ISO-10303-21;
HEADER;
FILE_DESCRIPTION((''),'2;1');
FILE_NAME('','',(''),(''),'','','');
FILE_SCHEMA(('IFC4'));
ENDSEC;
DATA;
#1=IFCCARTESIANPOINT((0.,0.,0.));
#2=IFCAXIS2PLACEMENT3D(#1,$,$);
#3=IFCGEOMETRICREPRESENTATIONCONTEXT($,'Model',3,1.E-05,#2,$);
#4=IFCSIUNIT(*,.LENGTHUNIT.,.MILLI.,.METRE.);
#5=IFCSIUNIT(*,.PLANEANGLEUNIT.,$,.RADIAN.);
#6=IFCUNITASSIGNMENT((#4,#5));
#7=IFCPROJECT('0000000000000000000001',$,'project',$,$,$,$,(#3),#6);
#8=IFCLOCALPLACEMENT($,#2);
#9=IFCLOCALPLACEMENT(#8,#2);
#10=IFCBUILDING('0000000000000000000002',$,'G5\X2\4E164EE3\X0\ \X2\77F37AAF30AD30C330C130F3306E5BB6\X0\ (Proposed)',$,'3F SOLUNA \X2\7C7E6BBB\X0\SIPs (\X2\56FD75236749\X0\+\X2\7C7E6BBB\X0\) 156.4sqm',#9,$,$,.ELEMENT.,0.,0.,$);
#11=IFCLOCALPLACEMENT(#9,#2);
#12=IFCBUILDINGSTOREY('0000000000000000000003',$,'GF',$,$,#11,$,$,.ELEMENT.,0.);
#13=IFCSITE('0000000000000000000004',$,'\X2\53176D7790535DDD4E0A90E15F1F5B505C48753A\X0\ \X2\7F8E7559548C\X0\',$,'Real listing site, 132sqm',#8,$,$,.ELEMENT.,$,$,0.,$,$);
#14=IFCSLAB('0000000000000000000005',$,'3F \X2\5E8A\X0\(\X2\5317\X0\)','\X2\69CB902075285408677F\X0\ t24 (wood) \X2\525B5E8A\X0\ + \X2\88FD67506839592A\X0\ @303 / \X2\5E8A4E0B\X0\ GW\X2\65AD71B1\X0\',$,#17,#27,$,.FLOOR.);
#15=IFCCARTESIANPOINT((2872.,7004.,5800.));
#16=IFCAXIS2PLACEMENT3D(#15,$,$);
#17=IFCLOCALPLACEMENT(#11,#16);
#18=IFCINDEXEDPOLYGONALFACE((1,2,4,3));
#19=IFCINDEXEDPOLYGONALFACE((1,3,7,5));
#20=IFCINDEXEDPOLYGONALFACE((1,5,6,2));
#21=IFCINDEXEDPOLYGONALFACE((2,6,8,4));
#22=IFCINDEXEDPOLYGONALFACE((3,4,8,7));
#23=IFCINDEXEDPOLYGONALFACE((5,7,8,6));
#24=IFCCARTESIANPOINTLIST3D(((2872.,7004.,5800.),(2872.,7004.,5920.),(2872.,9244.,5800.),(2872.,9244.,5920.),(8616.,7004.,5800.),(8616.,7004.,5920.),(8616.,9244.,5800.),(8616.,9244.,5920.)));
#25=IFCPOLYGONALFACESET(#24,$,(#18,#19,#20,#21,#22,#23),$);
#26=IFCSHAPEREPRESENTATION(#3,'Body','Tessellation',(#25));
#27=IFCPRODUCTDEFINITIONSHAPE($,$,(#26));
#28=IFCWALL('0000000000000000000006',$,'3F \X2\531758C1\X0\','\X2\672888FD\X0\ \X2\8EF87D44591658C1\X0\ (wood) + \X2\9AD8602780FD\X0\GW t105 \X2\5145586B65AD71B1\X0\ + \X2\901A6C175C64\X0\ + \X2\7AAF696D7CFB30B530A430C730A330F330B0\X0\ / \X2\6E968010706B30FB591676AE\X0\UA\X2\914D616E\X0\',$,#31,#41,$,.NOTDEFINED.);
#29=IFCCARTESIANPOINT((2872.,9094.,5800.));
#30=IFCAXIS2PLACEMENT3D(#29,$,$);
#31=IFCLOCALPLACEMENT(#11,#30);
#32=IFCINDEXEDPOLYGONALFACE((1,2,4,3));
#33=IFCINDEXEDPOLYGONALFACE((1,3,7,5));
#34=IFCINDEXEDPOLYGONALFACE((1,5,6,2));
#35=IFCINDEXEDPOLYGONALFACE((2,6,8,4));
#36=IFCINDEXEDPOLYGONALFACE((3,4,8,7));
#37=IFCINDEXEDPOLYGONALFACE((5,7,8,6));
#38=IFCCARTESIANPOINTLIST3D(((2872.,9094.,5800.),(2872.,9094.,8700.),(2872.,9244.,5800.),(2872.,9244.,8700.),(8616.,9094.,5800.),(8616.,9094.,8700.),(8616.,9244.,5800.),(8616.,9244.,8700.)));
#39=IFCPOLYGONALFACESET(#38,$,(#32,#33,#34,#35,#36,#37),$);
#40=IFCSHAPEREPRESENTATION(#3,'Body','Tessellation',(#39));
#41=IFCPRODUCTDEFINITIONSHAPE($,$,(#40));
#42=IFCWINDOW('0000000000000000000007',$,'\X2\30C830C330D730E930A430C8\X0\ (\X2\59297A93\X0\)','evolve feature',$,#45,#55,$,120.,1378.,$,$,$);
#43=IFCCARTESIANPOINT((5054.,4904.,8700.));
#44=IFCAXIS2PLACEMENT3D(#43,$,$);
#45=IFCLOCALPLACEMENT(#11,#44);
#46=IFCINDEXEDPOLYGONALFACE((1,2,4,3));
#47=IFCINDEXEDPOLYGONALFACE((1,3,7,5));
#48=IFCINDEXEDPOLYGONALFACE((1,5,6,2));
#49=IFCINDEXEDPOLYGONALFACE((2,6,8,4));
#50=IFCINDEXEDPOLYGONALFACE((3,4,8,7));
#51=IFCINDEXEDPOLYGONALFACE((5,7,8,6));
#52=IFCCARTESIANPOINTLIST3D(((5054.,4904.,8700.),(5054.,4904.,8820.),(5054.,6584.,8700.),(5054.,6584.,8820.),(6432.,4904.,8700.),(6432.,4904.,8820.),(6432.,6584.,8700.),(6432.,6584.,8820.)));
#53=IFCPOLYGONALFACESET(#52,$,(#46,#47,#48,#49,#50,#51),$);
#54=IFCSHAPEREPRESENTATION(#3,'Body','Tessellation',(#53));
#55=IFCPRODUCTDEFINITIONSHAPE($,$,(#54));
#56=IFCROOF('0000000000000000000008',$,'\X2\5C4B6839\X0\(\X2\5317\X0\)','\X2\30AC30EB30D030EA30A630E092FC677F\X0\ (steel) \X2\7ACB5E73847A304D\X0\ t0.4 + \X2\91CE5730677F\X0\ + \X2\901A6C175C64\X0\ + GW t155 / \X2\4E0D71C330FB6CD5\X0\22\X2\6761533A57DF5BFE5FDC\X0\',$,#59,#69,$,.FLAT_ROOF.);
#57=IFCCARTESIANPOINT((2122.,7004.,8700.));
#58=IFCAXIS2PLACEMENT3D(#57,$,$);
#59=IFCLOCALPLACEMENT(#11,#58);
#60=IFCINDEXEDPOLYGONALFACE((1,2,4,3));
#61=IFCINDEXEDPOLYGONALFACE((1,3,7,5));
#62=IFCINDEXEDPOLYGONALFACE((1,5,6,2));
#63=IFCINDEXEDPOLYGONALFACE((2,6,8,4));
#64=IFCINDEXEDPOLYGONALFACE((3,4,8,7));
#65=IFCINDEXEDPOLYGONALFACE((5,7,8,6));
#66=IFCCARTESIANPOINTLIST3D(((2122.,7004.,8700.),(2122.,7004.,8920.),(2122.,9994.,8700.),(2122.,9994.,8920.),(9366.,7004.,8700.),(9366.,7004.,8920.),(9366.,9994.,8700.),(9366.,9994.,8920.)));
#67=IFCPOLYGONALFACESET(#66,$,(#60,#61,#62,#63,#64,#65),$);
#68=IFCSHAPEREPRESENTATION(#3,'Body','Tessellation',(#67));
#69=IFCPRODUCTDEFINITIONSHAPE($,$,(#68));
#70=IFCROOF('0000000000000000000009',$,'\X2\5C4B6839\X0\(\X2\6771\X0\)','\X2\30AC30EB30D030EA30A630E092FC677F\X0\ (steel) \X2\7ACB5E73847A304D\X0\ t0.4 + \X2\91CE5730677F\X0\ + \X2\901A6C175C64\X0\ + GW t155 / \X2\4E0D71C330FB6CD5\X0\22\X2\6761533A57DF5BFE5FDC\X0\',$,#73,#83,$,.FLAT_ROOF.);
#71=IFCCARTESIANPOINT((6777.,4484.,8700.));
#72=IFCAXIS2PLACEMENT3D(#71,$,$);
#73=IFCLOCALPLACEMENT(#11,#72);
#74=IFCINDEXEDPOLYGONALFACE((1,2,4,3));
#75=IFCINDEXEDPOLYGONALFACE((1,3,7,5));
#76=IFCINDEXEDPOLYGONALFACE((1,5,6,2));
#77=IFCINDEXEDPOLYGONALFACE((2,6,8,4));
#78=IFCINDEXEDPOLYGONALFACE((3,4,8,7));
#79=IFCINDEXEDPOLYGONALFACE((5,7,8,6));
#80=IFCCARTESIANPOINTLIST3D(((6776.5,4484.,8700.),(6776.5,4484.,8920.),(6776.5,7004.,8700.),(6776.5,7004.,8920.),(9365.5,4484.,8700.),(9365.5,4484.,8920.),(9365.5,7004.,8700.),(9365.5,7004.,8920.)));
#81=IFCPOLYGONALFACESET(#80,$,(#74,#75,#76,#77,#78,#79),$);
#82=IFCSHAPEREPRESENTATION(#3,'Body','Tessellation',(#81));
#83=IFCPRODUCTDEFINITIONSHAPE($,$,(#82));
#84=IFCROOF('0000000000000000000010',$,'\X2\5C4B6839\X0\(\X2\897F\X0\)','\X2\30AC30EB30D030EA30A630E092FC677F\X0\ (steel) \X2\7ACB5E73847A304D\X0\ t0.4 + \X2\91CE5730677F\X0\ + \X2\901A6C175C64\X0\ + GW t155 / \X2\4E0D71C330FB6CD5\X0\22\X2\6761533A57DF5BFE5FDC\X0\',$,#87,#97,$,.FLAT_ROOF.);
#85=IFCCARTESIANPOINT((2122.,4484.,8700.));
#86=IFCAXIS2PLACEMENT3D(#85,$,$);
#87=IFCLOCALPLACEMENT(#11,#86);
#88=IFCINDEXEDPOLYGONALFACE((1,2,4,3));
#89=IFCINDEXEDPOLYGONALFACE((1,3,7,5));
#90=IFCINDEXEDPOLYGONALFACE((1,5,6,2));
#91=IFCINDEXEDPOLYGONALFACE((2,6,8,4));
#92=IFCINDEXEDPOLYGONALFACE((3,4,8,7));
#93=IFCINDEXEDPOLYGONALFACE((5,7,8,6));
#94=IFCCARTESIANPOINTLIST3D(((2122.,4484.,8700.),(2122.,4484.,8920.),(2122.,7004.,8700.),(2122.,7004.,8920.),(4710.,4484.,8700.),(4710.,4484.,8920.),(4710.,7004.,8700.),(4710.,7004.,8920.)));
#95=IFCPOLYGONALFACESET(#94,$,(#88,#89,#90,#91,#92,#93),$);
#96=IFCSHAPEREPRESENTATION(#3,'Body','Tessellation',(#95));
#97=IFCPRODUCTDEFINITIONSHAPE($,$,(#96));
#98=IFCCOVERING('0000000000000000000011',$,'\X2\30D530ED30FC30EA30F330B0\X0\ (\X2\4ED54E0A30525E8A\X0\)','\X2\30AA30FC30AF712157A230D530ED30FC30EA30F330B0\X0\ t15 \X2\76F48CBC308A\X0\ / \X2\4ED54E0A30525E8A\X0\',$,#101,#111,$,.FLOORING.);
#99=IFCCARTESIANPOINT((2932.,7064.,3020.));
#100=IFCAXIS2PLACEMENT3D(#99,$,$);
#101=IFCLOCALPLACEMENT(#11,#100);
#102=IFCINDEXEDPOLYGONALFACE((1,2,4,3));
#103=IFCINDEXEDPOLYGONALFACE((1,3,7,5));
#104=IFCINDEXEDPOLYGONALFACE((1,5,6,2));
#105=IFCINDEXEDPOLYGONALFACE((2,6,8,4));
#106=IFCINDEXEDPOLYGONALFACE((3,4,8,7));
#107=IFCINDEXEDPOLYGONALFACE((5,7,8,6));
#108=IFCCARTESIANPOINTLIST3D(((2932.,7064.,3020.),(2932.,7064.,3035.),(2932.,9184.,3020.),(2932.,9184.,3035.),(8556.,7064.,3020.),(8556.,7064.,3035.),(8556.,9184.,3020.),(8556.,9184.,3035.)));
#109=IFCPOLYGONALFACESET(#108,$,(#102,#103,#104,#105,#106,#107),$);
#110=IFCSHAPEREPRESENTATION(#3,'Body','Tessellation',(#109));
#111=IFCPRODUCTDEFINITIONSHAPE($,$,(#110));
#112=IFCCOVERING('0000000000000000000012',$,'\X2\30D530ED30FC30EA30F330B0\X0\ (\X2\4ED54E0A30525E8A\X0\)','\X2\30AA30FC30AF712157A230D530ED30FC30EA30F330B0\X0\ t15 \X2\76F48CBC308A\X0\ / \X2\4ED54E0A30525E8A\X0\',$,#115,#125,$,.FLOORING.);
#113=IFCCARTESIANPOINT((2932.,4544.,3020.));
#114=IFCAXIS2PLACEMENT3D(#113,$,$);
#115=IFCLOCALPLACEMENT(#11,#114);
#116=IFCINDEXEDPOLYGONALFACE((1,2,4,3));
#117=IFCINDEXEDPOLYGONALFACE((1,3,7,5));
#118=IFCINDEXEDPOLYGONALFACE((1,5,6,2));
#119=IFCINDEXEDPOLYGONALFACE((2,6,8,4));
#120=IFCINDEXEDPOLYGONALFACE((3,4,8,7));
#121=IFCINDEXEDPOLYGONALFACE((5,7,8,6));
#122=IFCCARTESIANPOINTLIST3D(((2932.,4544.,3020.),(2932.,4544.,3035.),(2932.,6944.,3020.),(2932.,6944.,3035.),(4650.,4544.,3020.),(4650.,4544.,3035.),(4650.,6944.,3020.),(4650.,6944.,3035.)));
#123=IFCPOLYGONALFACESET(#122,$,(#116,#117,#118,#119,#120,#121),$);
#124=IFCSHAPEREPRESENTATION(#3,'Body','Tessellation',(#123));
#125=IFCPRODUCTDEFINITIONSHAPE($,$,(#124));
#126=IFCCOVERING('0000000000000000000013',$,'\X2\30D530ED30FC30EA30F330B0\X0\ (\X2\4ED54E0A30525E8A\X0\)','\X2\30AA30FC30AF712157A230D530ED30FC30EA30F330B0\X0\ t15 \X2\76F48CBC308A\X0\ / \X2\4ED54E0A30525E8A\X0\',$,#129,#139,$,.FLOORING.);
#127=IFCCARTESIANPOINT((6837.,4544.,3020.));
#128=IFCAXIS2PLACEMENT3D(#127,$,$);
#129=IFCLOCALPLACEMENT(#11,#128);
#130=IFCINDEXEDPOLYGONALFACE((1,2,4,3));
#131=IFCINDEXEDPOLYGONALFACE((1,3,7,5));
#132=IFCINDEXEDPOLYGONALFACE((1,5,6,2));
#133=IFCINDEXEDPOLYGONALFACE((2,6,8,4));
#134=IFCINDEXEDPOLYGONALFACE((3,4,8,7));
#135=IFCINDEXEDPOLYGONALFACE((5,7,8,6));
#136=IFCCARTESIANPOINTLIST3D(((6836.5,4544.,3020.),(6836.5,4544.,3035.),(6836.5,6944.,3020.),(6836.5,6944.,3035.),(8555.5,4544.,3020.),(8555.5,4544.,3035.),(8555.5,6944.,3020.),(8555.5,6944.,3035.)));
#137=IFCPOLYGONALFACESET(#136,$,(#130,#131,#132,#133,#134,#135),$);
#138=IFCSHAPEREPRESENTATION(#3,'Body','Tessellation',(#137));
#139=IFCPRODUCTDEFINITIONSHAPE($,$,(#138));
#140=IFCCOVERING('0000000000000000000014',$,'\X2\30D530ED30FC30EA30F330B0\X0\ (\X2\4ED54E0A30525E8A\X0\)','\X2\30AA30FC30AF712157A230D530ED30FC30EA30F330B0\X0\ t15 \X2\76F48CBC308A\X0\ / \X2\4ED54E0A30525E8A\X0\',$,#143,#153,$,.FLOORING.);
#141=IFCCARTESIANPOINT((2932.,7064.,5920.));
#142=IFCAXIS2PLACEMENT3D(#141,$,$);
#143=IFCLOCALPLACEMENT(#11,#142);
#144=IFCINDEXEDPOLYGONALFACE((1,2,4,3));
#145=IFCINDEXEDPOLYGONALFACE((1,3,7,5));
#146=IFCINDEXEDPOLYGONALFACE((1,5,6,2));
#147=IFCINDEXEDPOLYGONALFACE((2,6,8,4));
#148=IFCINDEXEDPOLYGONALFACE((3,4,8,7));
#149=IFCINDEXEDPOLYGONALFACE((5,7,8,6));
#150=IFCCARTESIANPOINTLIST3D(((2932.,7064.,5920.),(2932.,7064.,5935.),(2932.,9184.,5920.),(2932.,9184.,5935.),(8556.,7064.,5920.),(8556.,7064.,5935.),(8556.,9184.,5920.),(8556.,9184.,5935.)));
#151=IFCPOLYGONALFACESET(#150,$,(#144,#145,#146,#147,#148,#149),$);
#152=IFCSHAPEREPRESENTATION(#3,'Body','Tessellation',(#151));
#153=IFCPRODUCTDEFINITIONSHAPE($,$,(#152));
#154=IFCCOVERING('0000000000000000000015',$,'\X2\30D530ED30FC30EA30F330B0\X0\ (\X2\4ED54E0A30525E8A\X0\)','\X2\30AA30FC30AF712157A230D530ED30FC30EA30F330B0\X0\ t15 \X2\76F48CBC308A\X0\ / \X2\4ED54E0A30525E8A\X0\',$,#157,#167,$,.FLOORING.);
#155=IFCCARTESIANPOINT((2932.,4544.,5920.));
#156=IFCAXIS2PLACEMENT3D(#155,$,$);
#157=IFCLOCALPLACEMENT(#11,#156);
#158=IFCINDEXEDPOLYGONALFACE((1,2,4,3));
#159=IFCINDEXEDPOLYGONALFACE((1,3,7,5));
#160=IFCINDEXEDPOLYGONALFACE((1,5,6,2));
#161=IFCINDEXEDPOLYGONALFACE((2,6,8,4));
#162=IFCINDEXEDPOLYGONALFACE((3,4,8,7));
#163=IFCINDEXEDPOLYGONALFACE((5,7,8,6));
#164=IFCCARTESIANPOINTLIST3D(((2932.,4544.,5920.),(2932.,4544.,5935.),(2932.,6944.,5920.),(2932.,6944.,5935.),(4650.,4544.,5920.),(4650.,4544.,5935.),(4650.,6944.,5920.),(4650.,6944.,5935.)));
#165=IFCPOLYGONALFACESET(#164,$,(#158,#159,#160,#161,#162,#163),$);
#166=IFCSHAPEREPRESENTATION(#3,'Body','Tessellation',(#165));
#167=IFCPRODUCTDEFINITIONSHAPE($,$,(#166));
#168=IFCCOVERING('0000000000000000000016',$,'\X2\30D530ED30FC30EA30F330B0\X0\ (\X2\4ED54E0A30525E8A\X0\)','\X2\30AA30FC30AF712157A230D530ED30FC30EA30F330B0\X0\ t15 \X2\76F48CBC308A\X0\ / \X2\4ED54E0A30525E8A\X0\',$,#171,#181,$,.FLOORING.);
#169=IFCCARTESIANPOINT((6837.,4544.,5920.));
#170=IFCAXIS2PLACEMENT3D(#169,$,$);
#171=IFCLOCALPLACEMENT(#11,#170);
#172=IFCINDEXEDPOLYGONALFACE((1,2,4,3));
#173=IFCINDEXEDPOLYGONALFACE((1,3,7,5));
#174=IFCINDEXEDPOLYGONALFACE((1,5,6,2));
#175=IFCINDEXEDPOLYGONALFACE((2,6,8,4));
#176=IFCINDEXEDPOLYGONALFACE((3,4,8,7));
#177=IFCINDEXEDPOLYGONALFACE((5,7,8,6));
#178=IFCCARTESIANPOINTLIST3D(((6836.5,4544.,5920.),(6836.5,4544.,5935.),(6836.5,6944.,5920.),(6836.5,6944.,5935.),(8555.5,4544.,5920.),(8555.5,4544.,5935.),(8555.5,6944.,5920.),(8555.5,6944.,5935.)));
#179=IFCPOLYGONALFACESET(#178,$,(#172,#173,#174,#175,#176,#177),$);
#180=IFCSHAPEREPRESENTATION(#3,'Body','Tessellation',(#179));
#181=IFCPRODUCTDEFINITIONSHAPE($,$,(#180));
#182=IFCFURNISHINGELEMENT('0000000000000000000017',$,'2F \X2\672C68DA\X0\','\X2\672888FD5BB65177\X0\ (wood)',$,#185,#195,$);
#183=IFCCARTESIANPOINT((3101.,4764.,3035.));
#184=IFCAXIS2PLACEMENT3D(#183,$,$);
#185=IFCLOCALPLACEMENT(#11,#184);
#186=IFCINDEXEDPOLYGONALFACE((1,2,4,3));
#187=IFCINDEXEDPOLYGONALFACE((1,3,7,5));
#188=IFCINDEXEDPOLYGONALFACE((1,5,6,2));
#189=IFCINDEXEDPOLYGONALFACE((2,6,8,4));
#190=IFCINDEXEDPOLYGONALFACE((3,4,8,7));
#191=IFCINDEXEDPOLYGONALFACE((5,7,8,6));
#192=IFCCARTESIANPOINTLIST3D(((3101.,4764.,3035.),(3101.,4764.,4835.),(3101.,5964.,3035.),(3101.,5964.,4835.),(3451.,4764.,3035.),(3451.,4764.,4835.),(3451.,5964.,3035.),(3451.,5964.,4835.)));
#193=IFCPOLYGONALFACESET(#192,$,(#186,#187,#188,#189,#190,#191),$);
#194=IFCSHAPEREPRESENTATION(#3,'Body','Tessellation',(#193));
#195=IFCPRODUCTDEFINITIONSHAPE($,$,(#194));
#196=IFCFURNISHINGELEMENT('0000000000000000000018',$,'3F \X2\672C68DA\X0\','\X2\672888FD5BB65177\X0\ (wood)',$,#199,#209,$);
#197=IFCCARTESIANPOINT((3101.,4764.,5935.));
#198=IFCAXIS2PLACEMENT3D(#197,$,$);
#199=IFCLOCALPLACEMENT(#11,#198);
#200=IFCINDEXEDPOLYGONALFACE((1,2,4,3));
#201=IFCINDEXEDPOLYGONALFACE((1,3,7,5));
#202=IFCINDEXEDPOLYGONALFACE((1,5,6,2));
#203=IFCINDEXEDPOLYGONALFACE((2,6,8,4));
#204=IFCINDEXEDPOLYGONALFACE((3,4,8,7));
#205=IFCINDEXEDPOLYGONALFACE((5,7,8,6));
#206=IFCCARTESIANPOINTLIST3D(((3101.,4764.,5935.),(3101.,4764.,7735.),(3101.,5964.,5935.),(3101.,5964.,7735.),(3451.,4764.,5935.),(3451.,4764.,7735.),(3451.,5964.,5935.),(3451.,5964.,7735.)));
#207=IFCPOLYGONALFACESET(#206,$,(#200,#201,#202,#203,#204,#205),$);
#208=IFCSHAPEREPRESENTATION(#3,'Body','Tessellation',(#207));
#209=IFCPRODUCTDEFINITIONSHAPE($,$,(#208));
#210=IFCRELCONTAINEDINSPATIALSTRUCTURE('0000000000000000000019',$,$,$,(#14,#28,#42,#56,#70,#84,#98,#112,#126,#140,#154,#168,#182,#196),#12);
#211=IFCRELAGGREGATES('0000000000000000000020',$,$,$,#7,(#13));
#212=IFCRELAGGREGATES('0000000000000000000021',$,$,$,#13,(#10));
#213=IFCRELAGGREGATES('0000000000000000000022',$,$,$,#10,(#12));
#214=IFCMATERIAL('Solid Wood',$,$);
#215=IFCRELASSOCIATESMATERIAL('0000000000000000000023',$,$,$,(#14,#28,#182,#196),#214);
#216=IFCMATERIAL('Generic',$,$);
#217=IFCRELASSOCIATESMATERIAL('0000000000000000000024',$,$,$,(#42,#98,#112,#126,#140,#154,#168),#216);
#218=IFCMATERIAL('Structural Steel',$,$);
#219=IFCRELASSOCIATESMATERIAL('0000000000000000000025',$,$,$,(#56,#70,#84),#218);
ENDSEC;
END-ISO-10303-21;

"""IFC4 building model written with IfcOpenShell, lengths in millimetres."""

from ifc_helpers import new_model, si_unit, frame, frame_2d, origin, place, context, project, spatial, rectangle, extrude, material, element, save


model = new_model("IFC4")

# Units and contexts
model_context = context("Model", 3, precision=1e-05, world=origin())
ifc_project = project(units=[si_unit("LENGTHUNIT", "METRE", prefix="MILLI"), si_unit("PLANEANGLEUNIT", "RADIAN")], contexts=[model_context])

# Site, building, storey
site_placement = place(None, origin())
site = spatial("IfcSite", under=ifc_project, at=site_placement, Name="北海道川上郡弟子屈町 美留和", ObjectType="Real listing site, 132sqm", CompositionType="ELEMENT", RefElevation=0.0)
building_placement = place(site_placement, origin())
building = spatial("IfcBuilding", under=site, at=building_placement, Name="G5世代 石窯キッチンの家 (Proposed)", ObjectType="3F SOLUNA 籾殻SIPs (国産杉+籾殻) 156.4sqm", CompositionType="ELEMENT", ElevationOfRefHeight=0.0, ElevationOfTerrain=0.0)
storey_placement = place(building_placement, origin())
storey = spatial("IfcBuildingStorey", under=building, at=storey_placement, Name="GF", CompositionType="ELEMENT", Elevation=0.0)

# Slab
ifc_material_1 = material(Name="Solid Wood")
slab_placement = place(storey_placement, frame((2872.0, 7004.0, 5800.0)))
element("IfcSlab", 1, at=slab_placement, inside=storey, material=ifc_material_1, Name="3F 床(北)", Description="構造用合板 t24 (wood) 剛床 + 製材根太 @303 / 床下 GW断熱", PredefinedType="FLOOR", context=model_context, shape_type="SweptSolid", body=[
    extrude(rectangle(XDim=5744.0, YDim=2240.0, at=frame_2d((2872.0, 1120.0))), frame((2872.0, 7004.0, 5800.0)), (0.0, 0.0, 1.0), 120.0),
])

# Wall
wall_1_placement = place(storey_placement, frame((2872.0, 9094.0, 5800.0)))
element("IfcWall", 2, at=wall_1_placement, inside=storey, material=ifc_material_1, Name="3F 北壁", Description="木製 軸組外壁 (wood) + 高性能GW t105 充填断熱 + 通気層 + 窯業系サイディング / 準耐火・外皮UA配慮", PredefinedType="NOTDEFINED", context=model_context, shape_type="SweptSolid", body=[
    extrude(rectangle(XDim=5744.0, YDim=150.0, at=frame_2d((2872.0, 75.0))), frame((2872.0, 9094.0, 5800.0)), (0.0, 0.0, 1.0), 2900.0),
])

# Window
ifc_material_2 = material(Name="Generic")
window_1_placement = place(storey_placement, frame((5054.0, 4904.0, 8700.0)))
element("IfcWindow", 3, at=window_1_placement, inside=storey, material=ifc_material_2, Name="トップライト (天窓)", Description="evolve feature", OverallHeight=120.0, OverallWidth=1378.0, context=model_context, shape_type="SweptSolid", body=[
    extrude(rectangle(XDim=1378.0, YDim=1680.0, at=frame_2d((689.0, 840.0))), frame((5054.0, 4904.0, 8700.0)), (0.0, 0.0, 1.0), 120.0),
])

# Roofs
ifc_material_3 = material(Name="Structural Steel")
roof_1_placement = place(storey_placement, frame((2122.0, 7004.0, 8700.0)))
element("IfcRoof", 4, at=roof_1_placement, inside=storey, material=ifc_material_3, Name="屋根(北)", Description="ガルバリウム鋼板 (steel) 立平葺き t0.4 + 野地板 + 通気層 + GW t155 / 不燃・法22条区域対応", PredefinedType="FLAT_ROOF", context=model_context, shape_type="SweptSolid", body=[
    extrude(rectangle(XDim=7244.0, YDim=2990.0, at=frame_2d((3622.0, 1495.0))), frame((2122.0, 7004.0, 8700.0)), (0.0, 0.0, 1.0), 220.0),
])
roof_2_placement = place(storey_placement, frame((6777.0, 4484.0, 8700.0)))
element("IfcRoof", 5, at=roof_2_placement, inside=storey, material=ifc_material_3, Name="屋根(東)", Description="ガルバリウム鋼板 (steel) 立平葺き t0.4 + 野地板 + 通気層 + GW t155 / 不燃・法22条区域対応", PredefinedType="FLAT_ROOF", context=model_context, shape_type="SweptSolid", body=[
    extrude(rectangle(XDim=2589.0, YDim=2520.0, at=frame_2d((1294.0, 1260.0))), frame((6777.0, 4484.0, 8700.0)), (0.0, 0.0, 1.0), 220.0),
])
roof_3_placement = place(storey_placement, frame((2122.0, 4484.0, 8700.0)))
element("IfcRoof", 6, at=roof_3_placement, inside=storey, material=ifc_material_3, Name="屋根(西)", Description="ガルバリウム鋼板 (steel) 立平葺き t0.4 + 野地板 + 通気層 + GW t155 / 不燃・法22条区域対応", PredefinedType="FLAT_ROOF", context=model_context, shape_type="SweptSolid", body=[
    extrude(rectangle(XDim=2588.0, YDim=2520.0, at=frame_2d((1294.0, 1260.0))), frame((2122.0, 4484.0, 8700.0)), (0.0, 0.0, 1.0), 220.0),
])

# Coverings
covering_1_placement = place(storey_placement, frame((2932.0, 7064.0, 3020.0)))
element("IfcCovering", 7, at=covering_1_placement, inside=storey, material=ifc_material_2, Name="フローリング (仕上げ床)", Description="オーク無垢フローリング t15 直貼り / 仕上げ床", PredefinedType="FLOORING", context=model_context, shape_type="SweptSolid", body=[
    extrude(rectangle(XDim=5624.0, YDim=2120.0, at=frame_2d((2812.0, 1060.0))), frame((2932.0, 7064.0, 3020.0)), (0.0, 0.0, 1.0), 15.0),
])
covering_2_placement = place(storey_placement, frame((2932.0, 4544.0, 3020.0)))
element("IfcCovering", 8, at=covering_2_placement, inside=storey, material=ifc_material_2, Name="フローリング (仕上げ床)", Description="オーク無垢フローリング t15 直貼り / 仕上げ床", PredefinedType="FLOORING", context=model_context, shape_type="SweptSolid", body=[
    extrude(rectangle(XDim=1718.0, YDim=2400.0, at=frame_2d((859.0, 1200.0))), frame((2932.0, 4544.0, 3020.0)), (0.0, 0.0, 1.0), 15.0),
])
covering_3_placement = place(storey_placement, frame((6837.0, 4544.0, 3020.0)))
element("IfcCovering", 9, at=covering_3_placement, inside=storey, material=ifc_material_2, Name="フローリング (仕上げ床)", Description="オーク無垢フローリング t15 直貼り / 仕上げ床", PredefinedType="FLOORING", context=model_context, shape_type="SweptSolid", body=[
    extrude(rectangle(XDim=1719.0, YDim=2400.0, at=frame_2d((859.0, 1200.0))), frame((6837.0, 4544.0, 3020.0)), (0.0, 0.0, 1.0), 15.0),
])
covering_4_placement = place(storey_placement, frame((2932.0, 7064.0, 5920.0)))
element("IfcCovering", 10, at=covering_4_placement, inside=storey, material=ifc_material_2, Name="フローリング (仕上げ床)", Description="オーク無垢フローリング t15 直貼り / 仕上げ床", PredefinedType="FLOORING", context=model_context, shape_type="SweptSolid", body=[
    extrude(rectangle(XDim=5624.0, YDim=2120.0, at=frame_2d((2812.0, 1060.0))), frame((2932.0, 7064.0, 5920.0)), (0.0, 0.0, 1.0), 15.0),
])
covering_5_placement = place(storey_placement, frame((2932.0, 4544.0, 5920.0)))
element("IfcCovering", 11, at=covering_5_placement, inside=storey, material=ifc_material_2, Name="フローリング (仕上げ床)", Description="オーク無垢フローリング t15 直貼り / 仕上げ床", PredefinedType="FLOORING", context=model_context, shape_type="SweptSolid", body=[
    extrude(rectangle(XDim=1718.0, YDim=2400.0, at=frame_2d((859.0, 1200.0))), frame((2932.0, 4544.0, 5920.0)), (0.0, 0.0, 1.0), 15.0),
])
covering_6_placement = place(storey_placement, frame((6837.0, 4544.0, 5920.0)))
element("IfcCovering", 12, at=covering_6_placement, inside=storey, material=ifc_material_2, Name="フローリング (仕上げ床)", Description="オーク無垢フローリング t15 直貼り / 仕上げ床", PredefinedType="FLOORING", context=model_context, shape_type="SweptSolid", body=[
    extrude(rectangle(XDim=1719.0, YDim=2400.0, at=frame_2d((859.0, 1200.0))), frame((6837.0, 4544.0, 5920.0)), (0.0, 0.0, 1.0), 15.0),
])

# Furnishing elements
furnishing_1_placement = place(storey_placement, frame((3101.0, 4764.0, 3035.0)))
element("IfcFurnishingElement", 13, at=furnishing_1_placement, inside=storey, material=ifc_material_1, Name="2F 本棚", Description="木製家具 (wood)", context=model_context, shape_type="SweptSolid", body=[
    extrude(rectangle(XDim=350.0, YDim=1200.0, at=frame_2d((175.0, 600.0))), frame((3101.0, 4764.0, 3035.0)), (0.0, 0.0, 1.0), 1800.0),
])
furnishing_2_placement = place(storey_placement, frame((3101.0, 4764.0, 5935.0)))
element("IfcFurnishingElement", 14, at=furnishing_2_placement, inside=storey, material=ifc_material_1, Name="3F 本棚", Description="木製家具 (wood)", context=model_context, shape_type="SweptSolid", body=[
    extrude(rectangle(XDim=350.0, YDim=1200.0, at=frame_2d((175.0, 600.0))), frame((3101.0, 4764.0, 5935.0)), (0.0, 0.0, 1.0), 1800.0),
])

save(model, "model.ifc")
